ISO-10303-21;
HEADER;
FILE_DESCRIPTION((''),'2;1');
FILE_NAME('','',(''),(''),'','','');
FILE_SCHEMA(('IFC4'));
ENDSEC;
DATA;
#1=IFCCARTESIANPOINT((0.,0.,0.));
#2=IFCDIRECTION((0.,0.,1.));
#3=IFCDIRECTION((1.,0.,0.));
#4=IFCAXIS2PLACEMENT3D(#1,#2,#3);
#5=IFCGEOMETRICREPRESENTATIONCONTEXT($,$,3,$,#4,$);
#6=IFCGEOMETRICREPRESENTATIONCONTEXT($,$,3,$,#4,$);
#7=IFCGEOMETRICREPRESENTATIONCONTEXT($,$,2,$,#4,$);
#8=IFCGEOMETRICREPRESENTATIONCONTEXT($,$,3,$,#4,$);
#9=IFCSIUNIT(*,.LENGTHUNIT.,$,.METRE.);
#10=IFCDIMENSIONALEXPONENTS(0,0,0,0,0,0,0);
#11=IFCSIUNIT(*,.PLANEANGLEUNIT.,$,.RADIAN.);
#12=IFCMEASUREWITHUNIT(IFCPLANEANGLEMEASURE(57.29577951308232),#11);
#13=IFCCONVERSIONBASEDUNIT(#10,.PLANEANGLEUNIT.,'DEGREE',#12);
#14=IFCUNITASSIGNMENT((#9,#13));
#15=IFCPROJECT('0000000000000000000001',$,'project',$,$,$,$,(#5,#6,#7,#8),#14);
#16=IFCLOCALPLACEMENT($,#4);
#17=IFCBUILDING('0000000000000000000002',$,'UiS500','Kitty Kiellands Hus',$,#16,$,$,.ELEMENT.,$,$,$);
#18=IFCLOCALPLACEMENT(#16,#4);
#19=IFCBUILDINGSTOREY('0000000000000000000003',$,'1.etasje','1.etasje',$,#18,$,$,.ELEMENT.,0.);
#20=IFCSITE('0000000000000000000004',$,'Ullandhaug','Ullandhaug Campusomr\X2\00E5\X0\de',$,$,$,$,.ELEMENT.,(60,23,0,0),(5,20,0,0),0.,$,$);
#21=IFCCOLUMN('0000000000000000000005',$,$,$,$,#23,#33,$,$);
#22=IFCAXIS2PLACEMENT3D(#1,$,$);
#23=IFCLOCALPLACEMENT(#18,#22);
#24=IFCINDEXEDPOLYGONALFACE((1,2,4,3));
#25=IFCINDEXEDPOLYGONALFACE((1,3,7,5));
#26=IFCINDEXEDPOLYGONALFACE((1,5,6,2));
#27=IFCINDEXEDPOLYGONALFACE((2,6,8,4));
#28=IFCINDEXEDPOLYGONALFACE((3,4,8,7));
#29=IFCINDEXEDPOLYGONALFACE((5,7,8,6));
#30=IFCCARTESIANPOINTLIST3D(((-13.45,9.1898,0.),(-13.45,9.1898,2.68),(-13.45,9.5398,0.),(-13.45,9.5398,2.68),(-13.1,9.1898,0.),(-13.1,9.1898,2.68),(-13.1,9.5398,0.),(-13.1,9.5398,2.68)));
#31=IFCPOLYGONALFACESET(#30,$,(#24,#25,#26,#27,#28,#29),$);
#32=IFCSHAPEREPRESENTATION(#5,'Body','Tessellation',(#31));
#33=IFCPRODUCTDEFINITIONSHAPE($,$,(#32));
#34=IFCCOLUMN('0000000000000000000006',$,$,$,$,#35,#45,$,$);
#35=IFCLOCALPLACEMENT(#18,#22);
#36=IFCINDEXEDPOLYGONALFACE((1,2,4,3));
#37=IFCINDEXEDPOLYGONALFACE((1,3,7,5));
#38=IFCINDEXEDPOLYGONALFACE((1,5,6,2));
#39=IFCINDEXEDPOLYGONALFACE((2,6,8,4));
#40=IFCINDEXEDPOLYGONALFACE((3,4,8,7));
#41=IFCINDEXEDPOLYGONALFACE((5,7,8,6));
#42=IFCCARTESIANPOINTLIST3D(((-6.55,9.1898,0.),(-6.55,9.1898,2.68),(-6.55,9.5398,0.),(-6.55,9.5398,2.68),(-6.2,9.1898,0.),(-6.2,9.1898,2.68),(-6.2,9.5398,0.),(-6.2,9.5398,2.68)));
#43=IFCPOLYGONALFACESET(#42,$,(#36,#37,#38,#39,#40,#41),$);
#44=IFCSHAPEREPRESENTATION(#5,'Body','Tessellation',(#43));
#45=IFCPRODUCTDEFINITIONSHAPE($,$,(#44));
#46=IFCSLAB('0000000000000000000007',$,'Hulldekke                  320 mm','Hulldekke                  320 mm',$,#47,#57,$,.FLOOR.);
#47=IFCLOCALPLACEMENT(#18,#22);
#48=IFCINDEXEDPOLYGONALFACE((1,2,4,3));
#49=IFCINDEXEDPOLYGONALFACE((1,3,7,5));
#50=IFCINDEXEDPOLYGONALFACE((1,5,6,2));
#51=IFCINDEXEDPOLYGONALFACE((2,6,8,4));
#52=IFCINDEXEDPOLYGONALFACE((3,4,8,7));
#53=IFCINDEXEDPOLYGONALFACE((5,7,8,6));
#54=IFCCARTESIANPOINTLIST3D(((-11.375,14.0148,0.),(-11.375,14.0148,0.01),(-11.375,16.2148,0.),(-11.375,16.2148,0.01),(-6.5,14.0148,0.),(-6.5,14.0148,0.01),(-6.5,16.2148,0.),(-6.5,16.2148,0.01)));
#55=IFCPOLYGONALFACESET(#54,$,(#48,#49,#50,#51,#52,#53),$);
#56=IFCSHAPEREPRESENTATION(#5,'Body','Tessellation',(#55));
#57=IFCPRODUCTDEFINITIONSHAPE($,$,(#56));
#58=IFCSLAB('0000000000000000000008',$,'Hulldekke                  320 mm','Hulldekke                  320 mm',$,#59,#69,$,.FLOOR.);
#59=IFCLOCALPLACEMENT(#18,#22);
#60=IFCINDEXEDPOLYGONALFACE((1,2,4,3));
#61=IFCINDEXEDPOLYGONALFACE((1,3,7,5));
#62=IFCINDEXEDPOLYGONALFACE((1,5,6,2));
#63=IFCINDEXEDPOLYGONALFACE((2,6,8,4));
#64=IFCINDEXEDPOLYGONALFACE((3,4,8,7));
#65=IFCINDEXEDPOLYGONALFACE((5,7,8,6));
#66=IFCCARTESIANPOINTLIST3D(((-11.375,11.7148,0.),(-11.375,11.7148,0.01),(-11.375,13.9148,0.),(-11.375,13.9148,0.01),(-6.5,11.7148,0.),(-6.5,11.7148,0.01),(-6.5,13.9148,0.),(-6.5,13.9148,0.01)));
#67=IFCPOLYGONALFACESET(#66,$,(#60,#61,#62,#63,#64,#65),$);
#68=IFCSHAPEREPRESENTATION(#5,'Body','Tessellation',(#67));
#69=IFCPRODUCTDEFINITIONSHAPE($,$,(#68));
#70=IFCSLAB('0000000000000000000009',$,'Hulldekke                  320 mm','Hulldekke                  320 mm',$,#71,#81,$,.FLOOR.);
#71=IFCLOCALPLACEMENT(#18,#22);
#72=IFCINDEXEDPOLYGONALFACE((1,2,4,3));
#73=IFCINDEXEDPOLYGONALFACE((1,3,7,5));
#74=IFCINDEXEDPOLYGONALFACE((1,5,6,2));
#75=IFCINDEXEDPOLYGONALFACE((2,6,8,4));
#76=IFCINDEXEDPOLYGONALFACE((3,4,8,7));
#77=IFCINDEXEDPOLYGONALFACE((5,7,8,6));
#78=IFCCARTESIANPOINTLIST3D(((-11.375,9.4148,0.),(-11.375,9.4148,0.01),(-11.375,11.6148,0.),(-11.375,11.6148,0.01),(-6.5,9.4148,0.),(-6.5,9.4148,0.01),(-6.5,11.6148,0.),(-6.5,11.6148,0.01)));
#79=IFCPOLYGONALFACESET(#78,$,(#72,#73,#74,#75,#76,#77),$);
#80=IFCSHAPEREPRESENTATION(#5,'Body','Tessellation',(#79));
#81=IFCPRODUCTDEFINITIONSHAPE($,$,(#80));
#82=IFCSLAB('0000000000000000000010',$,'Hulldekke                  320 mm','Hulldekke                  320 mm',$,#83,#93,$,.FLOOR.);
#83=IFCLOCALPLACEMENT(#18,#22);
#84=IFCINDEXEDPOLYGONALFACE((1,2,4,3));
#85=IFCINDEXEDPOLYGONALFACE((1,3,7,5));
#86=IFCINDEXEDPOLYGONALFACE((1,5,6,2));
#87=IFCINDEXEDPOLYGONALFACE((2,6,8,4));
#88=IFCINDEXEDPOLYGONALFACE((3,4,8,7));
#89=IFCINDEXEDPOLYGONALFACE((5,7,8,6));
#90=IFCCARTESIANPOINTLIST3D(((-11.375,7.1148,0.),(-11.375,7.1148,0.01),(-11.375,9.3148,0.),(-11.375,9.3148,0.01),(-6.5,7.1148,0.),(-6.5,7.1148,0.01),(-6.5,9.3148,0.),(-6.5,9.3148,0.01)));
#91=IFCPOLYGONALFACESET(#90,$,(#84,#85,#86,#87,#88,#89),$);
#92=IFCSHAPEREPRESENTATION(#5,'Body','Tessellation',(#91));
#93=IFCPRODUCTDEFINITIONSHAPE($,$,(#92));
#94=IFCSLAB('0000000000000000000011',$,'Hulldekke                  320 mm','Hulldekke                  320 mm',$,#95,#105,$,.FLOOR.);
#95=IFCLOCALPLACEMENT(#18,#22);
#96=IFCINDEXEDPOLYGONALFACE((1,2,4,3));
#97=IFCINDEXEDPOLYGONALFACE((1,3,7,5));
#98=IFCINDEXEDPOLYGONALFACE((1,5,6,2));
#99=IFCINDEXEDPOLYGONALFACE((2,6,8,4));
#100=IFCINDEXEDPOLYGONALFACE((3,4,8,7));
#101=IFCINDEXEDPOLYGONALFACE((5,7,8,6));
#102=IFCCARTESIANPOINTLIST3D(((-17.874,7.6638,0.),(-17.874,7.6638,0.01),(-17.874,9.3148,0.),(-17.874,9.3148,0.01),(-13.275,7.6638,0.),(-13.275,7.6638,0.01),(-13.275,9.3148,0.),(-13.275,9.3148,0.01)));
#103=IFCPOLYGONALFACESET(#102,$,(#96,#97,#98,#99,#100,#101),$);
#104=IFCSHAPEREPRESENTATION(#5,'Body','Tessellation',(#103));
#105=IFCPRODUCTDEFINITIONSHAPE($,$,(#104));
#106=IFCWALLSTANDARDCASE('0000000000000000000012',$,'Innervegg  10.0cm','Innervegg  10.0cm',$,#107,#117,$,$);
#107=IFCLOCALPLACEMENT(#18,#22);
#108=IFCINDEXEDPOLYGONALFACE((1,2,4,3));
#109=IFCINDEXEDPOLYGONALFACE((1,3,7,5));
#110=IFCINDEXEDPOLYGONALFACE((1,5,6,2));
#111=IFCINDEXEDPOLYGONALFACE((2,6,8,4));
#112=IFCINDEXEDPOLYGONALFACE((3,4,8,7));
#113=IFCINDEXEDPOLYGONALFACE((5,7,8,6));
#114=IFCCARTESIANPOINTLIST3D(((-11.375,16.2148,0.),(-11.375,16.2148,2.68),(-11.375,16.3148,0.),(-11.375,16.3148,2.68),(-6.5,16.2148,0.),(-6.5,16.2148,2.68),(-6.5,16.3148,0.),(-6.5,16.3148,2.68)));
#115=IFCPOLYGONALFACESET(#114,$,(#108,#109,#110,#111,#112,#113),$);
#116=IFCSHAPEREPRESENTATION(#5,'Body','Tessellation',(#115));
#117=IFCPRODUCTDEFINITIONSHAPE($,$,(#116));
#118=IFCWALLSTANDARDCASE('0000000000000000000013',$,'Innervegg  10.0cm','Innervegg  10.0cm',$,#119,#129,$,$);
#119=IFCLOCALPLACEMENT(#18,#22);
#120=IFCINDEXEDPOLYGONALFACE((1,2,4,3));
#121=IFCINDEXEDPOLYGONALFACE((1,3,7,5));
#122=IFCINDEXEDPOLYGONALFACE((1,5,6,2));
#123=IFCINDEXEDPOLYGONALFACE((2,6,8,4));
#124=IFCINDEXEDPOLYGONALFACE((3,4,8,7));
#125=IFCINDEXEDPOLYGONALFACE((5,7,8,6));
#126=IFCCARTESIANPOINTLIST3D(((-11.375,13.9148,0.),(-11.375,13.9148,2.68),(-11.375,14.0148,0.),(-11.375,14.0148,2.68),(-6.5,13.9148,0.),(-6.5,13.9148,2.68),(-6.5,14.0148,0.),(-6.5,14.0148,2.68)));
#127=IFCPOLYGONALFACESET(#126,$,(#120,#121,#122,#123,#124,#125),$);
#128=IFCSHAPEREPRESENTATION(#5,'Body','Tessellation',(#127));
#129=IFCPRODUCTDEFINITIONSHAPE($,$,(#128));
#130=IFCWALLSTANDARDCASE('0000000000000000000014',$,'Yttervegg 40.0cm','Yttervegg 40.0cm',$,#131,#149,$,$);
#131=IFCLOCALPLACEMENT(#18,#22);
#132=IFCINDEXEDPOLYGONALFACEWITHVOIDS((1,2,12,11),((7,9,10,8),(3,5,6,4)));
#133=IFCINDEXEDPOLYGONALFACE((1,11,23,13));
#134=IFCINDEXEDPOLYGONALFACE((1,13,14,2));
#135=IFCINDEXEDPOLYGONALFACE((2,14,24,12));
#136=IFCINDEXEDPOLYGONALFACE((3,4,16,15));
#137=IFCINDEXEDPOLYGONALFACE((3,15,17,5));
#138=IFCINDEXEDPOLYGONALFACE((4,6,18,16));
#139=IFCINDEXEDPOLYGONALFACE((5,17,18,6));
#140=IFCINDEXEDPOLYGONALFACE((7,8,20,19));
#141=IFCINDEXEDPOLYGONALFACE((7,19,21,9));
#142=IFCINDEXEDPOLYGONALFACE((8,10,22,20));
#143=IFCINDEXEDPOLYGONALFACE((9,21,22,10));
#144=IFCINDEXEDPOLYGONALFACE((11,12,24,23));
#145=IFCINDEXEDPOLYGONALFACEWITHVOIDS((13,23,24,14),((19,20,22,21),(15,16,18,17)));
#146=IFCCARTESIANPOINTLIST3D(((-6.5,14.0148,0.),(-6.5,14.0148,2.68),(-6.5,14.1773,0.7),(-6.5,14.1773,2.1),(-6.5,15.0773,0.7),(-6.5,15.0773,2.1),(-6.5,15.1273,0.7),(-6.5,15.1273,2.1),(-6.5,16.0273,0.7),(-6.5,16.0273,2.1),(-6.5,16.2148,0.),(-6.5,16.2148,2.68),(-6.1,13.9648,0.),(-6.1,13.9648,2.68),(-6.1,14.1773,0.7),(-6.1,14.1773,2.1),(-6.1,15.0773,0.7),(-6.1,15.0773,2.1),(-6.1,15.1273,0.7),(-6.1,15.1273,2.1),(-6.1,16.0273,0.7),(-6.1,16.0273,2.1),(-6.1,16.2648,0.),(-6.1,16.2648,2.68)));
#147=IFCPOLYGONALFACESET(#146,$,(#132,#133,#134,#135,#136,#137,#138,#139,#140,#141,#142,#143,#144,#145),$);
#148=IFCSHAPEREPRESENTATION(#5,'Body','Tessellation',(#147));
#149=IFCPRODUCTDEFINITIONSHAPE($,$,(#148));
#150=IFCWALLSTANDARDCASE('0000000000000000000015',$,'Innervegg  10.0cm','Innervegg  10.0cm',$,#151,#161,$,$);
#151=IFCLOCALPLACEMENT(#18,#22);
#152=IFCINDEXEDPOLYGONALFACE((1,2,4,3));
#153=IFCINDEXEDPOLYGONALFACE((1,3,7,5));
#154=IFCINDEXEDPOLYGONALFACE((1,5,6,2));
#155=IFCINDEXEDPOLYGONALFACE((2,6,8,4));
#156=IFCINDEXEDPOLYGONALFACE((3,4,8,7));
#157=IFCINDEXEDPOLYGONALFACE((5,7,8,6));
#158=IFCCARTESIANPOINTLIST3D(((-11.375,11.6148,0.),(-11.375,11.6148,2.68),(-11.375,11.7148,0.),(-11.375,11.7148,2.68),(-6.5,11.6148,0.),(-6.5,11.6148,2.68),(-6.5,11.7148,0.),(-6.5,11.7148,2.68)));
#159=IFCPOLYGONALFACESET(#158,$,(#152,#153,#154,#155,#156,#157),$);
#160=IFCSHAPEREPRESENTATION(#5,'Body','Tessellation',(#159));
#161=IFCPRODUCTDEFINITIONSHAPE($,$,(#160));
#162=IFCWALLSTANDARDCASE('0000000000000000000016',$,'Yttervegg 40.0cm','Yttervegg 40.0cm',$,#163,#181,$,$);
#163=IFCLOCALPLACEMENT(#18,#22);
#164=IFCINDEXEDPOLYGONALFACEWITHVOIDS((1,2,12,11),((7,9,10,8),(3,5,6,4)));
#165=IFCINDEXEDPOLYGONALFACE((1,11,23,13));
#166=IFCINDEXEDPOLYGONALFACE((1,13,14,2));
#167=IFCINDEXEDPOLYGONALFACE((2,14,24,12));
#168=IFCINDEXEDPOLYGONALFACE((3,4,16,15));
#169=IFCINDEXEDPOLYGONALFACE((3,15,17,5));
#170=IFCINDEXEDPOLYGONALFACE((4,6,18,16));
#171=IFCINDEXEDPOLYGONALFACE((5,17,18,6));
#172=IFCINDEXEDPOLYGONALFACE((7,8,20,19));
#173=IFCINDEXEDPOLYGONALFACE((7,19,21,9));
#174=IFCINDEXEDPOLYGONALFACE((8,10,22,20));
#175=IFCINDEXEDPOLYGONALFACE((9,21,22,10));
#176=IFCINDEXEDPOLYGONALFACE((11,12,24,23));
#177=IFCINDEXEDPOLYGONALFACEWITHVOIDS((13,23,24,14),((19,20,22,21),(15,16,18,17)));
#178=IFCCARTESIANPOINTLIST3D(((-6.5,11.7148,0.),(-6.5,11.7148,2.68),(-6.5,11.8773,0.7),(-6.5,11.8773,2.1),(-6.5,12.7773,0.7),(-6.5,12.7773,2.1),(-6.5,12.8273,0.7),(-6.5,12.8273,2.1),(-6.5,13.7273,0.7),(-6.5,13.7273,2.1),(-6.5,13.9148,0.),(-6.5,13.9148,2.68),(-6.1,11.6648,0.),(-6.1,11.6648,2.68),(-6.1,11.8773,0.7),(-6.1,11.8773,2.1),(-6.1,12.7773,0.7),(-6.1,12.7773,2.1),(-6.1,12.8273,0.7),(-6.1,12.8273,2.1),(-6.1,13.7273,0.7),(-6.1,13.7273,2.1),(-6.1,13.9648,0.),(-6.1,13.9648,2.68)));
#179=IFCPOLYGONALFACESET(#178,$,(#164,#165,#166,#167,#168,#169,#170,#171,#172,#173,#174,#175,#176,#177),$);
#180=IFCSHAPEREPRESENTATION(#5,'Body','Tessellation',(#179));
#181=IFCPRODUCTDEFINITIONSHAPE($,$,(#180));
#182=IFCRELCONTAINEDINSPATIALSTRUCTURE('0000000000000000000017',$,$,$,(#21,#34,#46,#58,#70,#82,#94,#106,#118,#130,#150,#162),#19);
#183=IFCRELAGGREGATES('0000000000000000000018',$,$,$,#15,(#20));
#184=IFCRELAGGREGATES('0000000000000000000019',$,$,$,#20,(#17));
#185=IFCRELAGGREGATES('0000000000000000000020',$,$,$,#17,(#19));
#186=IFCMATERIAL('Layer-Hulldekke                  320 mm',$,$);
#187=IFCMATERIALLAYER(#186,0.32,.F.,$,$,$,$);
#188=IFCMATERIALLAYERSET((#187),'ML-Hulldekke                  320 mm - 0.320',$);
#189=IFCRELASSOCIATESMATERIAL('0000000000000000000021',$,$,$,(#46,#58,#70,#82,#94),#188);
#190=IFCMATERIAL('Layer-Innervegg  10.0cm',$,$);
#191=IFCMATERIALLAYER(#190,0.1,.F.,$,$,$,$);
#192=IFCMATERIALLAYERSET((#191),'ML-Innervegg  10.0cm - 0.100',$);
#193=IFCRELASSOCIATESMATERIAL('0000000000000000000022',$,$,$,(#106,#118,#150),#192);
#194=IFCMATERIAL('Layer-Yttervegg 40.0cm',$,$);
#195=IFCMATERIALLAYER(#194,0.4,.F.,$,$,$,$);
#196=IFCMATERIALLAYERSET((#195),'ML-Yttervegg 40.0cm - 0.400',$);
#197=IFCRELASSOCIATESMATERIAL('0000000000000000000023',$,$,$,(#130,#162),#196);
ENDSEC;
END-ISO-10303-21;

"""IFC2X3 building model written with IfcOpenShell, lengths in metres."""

from ifc_helpers import new_model, entity, si_unit, converted_unit, frame, origin_with_axes, origin_2d_with_axis, place, context, project, spatial, polyline, rectangle, outline, extrude, material, layer, layer_set, layer_usage, element, save


model = new_model("IFC2X3")

# Units and contexts
context_of_model_1 = context(None, 3, world=origin_with_axes())
context_of_model_2 = context(None, 3, world=origin_with_axes())
context_of_model_3 = context(None, 2, world=origin_with_axes())
context_of_model_4 = context(None, 3, world=origin_with_axes())
ifc_project = project(units=[si_unit("LENGTHUNIT", "METRE"), converted_unit("PLANEANGLEUNIT", "DEGREE", entity("IfcPlaneAngleMeasure", 57.29577951308232), si_unit("PLANEANGLEUNIT", "RADIAN"), dimensions=[0, 0, 0, 0, 0, 0, 0])], contexts=[context_of_model_1, context_of_model_2, context_of_model_3, context_of_model_4])

# Site, building, storey
site = spatial("IfcSite", under=ifc_project, Name="Ullandhaug", Description="Ullandhaug Campusområde", CompositionType="ELEMENT", RefLatitude=(60, 23, 0, 0), RefLongitude=(5, 20, 0, 0), RefElevation=0.0)
building_placement = place(None, origin_with_axes())
building = spatial("IfcBuilding", under=site, at=building_placement, Name="UiS500", Description="Kitty Kiellands Hus", CompositionType="ELEMENT")
storey_placement = place(building_placement, origin_with_axes())
storey = spatial("IfcBuildingStorey", under=building, at=storey_placement, Name="1.etasje", Description="1.etasje", CompositionType="ELEMENT", Elevation=0.0)

# Columns
for number, where, z_axis, x_axis in (
    (1, (-13.275, 9.3648, 0.0), (0.0, 0.0, 1.0), (1.0, 0.0, 0.0)),
    (2, (-6.375, 9.3648, 0.0), (0.0, 0.0, 1.0), (1.0, 0.0, 0.0)),
):
    element("IfcColumn", number, at=place(storey_placement, frame(where, z_axis=z_axis, x_axis=x_axis)), inside=storey, context=context_of_model_1, shape_type="SweptSolid", body=[
        extrude(rectangle(XDim=0.35, YDim=0.35, at=origin_2d_with_axis()), origin_with_axes(), (0.0, 0.0, 1.0), 2.68),
    ])

# Slabs
ifc_material_1 = material(Name="Layer-Hulldekke                  320 mm")
ifc_layer_1 = layer(ifc_material_1, 0.32, ventilated=False)
ifc_layer_set_1 = layer_set([ifc_layer_1], Name="ML-Hulldekke                  320 mm - 0.320")
ifc_layer_usage_1 = layer_usage(ifc_layer_set_1, "AXIS2", "POSITIVE", 0.0)
slab_1_placement = place(storey_placement, frame((-11.375, 14.0148, 0.0), z_axis=(0.0, 0.0, 1.0), x_axis=(1.0, 0.0, 0.0)))
element("IfcSlab", 3, at=slab_1_placement, inside=storey, material=ifc_layer_usage_1, Name="Hulldekke                  320 mm", Description="Hulldekke                  320 mm", PredefinedType="FLOOR", context=context_of_model_1, shape_type="SweptSolid", body=[
    extrude(outline(polyline([(0.0, 0.0), (4.875, 0.0), (4.875, 2.2), (0.0, 2.2), (0.0, 0.0)])), origin_with_axes(), (0.0, 0.0, 1.0), 0.01),
])
slab_2_placement = place(storey_placement, frame((-11.375, 11.7148, 0.0), z_axis=(0.0, 0.0, 1.0), x_axis=(1.0, 0.0, 0.0)))
element("IfcSlab", 4, at=slab_2_placement, inside=storey, material=ifc_layer_usage_1, Name="Hulldekke                  320 mm", Description="Hulldekke                  320 mm", PredefinedType="FLOOR", context=context_of_model_1, shape_type="SweptSolid", body=[
    extrude(outline(polyline([(0.0, 0.0), (4.875, 0.0), (4.875, 2.2), (0.0, 2.2), (0.0, 0.0)])), origin_with_axes(), (0.0, 0.0, 1.0), 0.01),
])
slab_3_placement = place(storey_placement, frame((-11.375, 9.4148, 0.0), z_axis=(0.0, 0.0, 1.0), x_axis=(1.0, 0.0, 0.0)))
element("IfcSlab", 5, at=slab_3_placement, inside=storey, material=ifc_layer_usage_1, Name="Hulldekke                  320 mm", Description="Hulldekke                  320 mm", PredefinedType="FLOOR", context=context_of_model_1, shape_type="SweptSolid", body=[
    extrude(outline(polyline([(0.0, 0.0), (4.875, 0.0), (4.875, 2.2), (0.0, 2.2), (0.0, 0.0)])), origin_with_axes(), (0.0, 0.0, 1.0), 0.01),
])
slab_4_placement = place(storey_placement, frame((-6.5, 9.3148, 0.0), z_axis=(0.0, 0.0, 1.0), x_axis=(1.0, 0.0, 0.0)))
element("IfcSlab", 6, at=slab_4_placement, inside=storey, material=ifc_layer_usage_1, Name="Hulldekke                  320 mm", Description="Hulldekke                  320 mm", PredefinedType="FLOOR", context=context_of_model_1, shape_type="SweptSolid", body=[
    extrude(outline(polyline([(0.0, 0.0), (4.875, 0.0), (4.875, 2.2), (0.0, 2.2), (0.0, 0.0)])), frame((0.0, 0.0, 0.0), z_axis=(0.0, 0.0, 1.0), x_axis=(-1.0, 0.0, 0.0)), (0.0, 0.0, 1.0), 0.01),
])
slab_5_placement = place(storey_placement, frame((-13.275, 9.3148, 0.0), z_axis=(0.0, 0.0, 1.0), x_axis=(1.0, 0.0, 0.0)))
element("IfcSlab", 7, at=slab_5_placement, inside=storey, material=ifc_layer_usage_1, Name="Hulldekke                  320 mm", Description="Hulldekke                  320 mm", PredefinedType="FLOOR", context=context_of_model_1, shape_type="SweptSolid", body=[
    extrude(outline(polyline([(0.0, 0.0), (4.599, 0.0), (4.599, 1.651), (0.0, 1.651), (0.0, 0.0)])), frame((0.0, 0.0, 0.0), z_axis=(0.0, 0.0, 1.0), x_axis=(-1.0, 0.0, 0.0)), (0.0, 0.0, 1.0), 0.01),
])

# Walls
ifc_material_2 = material(Name="Layer-Innervegg  10.0cm")
ifc_layer_2 = layer(ifc_material_2, 0.1, ventilated=False)
ifc_layer_set_2 = layer_set([ifc_layer_2], Name="ML-Innervegg  10.0cm - 0.100")
ifc_layer_usage_2 = layer_usage(ifc_layer_set_2, "AXIS2", "POSITIVE", 0.0)
for number, where, z_axis, x_axis, name in (
    (8, (-11.375, 16.2148, 0.0), (0.0, 0.0, 1.0), (1.0, 0.0, 0.0), "Innervegg  10.0cm"),
    (9, (-11.375, 13.9148, 0.0), (0.0, 0.0, 1.0), (1.0, 0.0, 0.0), "Innervegg  10.0cm"),
):
    element("IfcWallStandardCase", number, at=place(storey_placement, frame(where, z_axis=z_axis, x_axis=x_axis)), inside=storey, material=ifc_layer_usage_2, Name=name, Description="Innervegg  10.0cm", context=context_of_model_1, shape_type="SweptSolid", body=[
        extrude(outline(polyline([(0.0, 0.0), (4.875, 0.0), (4.875, 0.1), (0.0, 0.1), (0.0, 0.0)])), origin_with_axes(), (0.0, 0.0, 1.0), 2.68),
    ])

# Wall, openings
ifc_material_3 = material(Name="Layer-Yttervegg 40.0cm")
ifc_layer_3 = layer(ifc_material_3, 0.4, ventilated=False)
ifc_layer_set_3 = layer_set([ifc_layer_3], Name="ML-Yttervegg 40.0cm - 0.400")
ifc_layer_usage_3 = layer_usage(ifc_layer_set_3, "AXIS2", "POSITIVE", 0.0)
wall_1_placement = place(storey_placement, frame((-6.1, 13.9648, 0.0), z_axis=(0.0, 0.0, 1.0), x_axis=(0.0, 1.0, 0.0)))
wall_1 = element("IfcWallStandardCase", 10, at=wall_1_placement, inside=storey, material=ifc_layer_usage_3, Name="Yttervegg 40.0cm", Description="Yttervegg 40.0cm", context=context_of_model_1, shape_type="SweptSolid", body=[
    extrude(outline(polyline([(0.0, 0.0), (2.3, 0.0), (2.25, 0.4), (0.05, 0.4), (0.0, 0.0)])), frame((0.0, 0.0, 0.0), z_axis=(0.0, 0.0, 1.0), x_axis=(1.0, 0.0, 0.0)), (0.0, 0.0, 1.0), 2.68),
])
opening_1_placement = place(wall_1_placement, frame((0.2125, 0.4, 0.7), z_axis=(0.0, 0.0, 1.0), x_axis=(1.0, 0.0, 0.0)))
element("IfcOpeningElement", 11, at=opening_1_placement, cuts=wall_1, context=context_of_model_1, shape_type="SweptSolid", body=[
    extrude(outline(polyline([(0.0, 0.0), (1.4, 0.0), (1.4, 0.9), (0.0, 0.9), (0.0, 0.0)])), frame((0.0, 0.0, 0.0), z_axis=(0.0, 1.0, 0.0), x_axis=(0.0, 0.0, 1.0)), (0.0, 0.0, -1.0), 0.4),
])
opening_2_placement = place(wall_1_placement, frame((1.1625, 0.4, 0.7), z_axis=(0.0, 0.0, 1.0), x_axis=(1.0, 0.0, 0.0)))
element("IfcOpeningElement", 12, at=opening_2_placement, cuts=wall_1, context=context_of_model_1, shape_type="SweptSolid", body=[
    extrude(outline(polyline([(0.0, 0.0), (1.4, 0.0), (1.4, 0.9), (0.0, 0.9), (0.0, 0.0)])), frame((0.0, 0.0, 0.0), z_axis=(0.0, 1.0, 0.0), x_axis=(0.0, 0.0, 1.0)), (0.0, 0.0, -1.0), 0.4),
])

# Wall
wall_2_placement = place(storey_placement, frame((-11.375, 11.6148, 0.0), z_axis=(0.0, 0.0, 1.0), x_axis=(1.0, 0.0, 0.0)))
element("IfcWallStandardCase", 13, at=wall_2_placement, inside=storey, material=ifc_layer_usage_2, Name="Innervegg  10.0cm", Description="Innervegg  10.0cm", context=context_of_model_1, shape_type="SweptSolid", body=[
    extrude(outline(polyline([(0.0, 0.0), (4.875, 0.0), (4.875, 0.1), (0.0, 0.1), (0.0, 0.0)])), origin_with_axes(), (0.0, 0.0, 1.0), 2.68),
])

# Wall, openings
wall_3_placement = place(storey_placement, frame((-6.1, 11.6648, 0.0), z_axis=(0.0, 0.0, 1.0), x_axis=(0.0, 1.0, 0.0)))
wall_3 = element("IfcWallStandardCase", 14, at=wall_3_placement, inside=storey, material=ifc_layer_usage_3, Name="Yttervegg 40.0cm", Description="Yttervegg 40.0cm", context=context_of_model_1, shape_type="SweptSolid", body=[
    extrude(outline(polyline([(0.0, 0.0), (2.3, 0.0), (2.25, 0.4), (0.05, 0.4), (0.0, 0.0)])), frame((0.0, 0.0, 0.0), z_axis=(0.0, 0.0, 1.0), x_axis=(1.0, 0.0, 0.0)), (0.0, 0.0, 1.0), 2.68),
])
opening_3_placement = place(wall_3_placement, frame((0.2125, 0.4, 0.7), z_axis=(0.0, 0.0, 1.0), x_axis=(1.0, 0.0, 0.0)))
element("IfcOpeningElement", 15, at=opening_3_placement, cuts=wall_3, context=context_of_model_1, shape_type="SweptSolid", body=[
    extrude(outline(polyline([(0.0, 0.0), (1.4, 0.0), (1.4, 0.9), (0.0, 0.9), (0.0, 0.0)])), frame((0.0, 0.0, 0.0), z_axis=(0.0, 1.0, 0.0), x_axis=(0.0, 0.0, 1.0)), (0.0, 0.0, -1.0), 0.4),
])
opening_4_placement = place(wall_3_placement, frame((1.1625, 0.4, 0.7), z_axis=(0.0, 0.0, 1.0), x_axis=(1.0, 0.0, 0.0)))
element("IfcOpeningElement", 16, at=opening_4_placement, cuts=wall_3, context=context_of_model_1, shape_type="SweptSolid", body=[
    extrude(outline(polyline([(0.0, 0.0), (1.4, 0.0), (1.4, 0.9), (0.0, 0.9), (0.0, 0.0)])), frame((0.0, 0.0, 0.0), z_axis=(0.0, 1.0, 0.0), x_axis=(0.0, 0.0, 1.0)), (0.0, 0.0, -1.0), 0.4),
])

save(model, "model.ifc")
